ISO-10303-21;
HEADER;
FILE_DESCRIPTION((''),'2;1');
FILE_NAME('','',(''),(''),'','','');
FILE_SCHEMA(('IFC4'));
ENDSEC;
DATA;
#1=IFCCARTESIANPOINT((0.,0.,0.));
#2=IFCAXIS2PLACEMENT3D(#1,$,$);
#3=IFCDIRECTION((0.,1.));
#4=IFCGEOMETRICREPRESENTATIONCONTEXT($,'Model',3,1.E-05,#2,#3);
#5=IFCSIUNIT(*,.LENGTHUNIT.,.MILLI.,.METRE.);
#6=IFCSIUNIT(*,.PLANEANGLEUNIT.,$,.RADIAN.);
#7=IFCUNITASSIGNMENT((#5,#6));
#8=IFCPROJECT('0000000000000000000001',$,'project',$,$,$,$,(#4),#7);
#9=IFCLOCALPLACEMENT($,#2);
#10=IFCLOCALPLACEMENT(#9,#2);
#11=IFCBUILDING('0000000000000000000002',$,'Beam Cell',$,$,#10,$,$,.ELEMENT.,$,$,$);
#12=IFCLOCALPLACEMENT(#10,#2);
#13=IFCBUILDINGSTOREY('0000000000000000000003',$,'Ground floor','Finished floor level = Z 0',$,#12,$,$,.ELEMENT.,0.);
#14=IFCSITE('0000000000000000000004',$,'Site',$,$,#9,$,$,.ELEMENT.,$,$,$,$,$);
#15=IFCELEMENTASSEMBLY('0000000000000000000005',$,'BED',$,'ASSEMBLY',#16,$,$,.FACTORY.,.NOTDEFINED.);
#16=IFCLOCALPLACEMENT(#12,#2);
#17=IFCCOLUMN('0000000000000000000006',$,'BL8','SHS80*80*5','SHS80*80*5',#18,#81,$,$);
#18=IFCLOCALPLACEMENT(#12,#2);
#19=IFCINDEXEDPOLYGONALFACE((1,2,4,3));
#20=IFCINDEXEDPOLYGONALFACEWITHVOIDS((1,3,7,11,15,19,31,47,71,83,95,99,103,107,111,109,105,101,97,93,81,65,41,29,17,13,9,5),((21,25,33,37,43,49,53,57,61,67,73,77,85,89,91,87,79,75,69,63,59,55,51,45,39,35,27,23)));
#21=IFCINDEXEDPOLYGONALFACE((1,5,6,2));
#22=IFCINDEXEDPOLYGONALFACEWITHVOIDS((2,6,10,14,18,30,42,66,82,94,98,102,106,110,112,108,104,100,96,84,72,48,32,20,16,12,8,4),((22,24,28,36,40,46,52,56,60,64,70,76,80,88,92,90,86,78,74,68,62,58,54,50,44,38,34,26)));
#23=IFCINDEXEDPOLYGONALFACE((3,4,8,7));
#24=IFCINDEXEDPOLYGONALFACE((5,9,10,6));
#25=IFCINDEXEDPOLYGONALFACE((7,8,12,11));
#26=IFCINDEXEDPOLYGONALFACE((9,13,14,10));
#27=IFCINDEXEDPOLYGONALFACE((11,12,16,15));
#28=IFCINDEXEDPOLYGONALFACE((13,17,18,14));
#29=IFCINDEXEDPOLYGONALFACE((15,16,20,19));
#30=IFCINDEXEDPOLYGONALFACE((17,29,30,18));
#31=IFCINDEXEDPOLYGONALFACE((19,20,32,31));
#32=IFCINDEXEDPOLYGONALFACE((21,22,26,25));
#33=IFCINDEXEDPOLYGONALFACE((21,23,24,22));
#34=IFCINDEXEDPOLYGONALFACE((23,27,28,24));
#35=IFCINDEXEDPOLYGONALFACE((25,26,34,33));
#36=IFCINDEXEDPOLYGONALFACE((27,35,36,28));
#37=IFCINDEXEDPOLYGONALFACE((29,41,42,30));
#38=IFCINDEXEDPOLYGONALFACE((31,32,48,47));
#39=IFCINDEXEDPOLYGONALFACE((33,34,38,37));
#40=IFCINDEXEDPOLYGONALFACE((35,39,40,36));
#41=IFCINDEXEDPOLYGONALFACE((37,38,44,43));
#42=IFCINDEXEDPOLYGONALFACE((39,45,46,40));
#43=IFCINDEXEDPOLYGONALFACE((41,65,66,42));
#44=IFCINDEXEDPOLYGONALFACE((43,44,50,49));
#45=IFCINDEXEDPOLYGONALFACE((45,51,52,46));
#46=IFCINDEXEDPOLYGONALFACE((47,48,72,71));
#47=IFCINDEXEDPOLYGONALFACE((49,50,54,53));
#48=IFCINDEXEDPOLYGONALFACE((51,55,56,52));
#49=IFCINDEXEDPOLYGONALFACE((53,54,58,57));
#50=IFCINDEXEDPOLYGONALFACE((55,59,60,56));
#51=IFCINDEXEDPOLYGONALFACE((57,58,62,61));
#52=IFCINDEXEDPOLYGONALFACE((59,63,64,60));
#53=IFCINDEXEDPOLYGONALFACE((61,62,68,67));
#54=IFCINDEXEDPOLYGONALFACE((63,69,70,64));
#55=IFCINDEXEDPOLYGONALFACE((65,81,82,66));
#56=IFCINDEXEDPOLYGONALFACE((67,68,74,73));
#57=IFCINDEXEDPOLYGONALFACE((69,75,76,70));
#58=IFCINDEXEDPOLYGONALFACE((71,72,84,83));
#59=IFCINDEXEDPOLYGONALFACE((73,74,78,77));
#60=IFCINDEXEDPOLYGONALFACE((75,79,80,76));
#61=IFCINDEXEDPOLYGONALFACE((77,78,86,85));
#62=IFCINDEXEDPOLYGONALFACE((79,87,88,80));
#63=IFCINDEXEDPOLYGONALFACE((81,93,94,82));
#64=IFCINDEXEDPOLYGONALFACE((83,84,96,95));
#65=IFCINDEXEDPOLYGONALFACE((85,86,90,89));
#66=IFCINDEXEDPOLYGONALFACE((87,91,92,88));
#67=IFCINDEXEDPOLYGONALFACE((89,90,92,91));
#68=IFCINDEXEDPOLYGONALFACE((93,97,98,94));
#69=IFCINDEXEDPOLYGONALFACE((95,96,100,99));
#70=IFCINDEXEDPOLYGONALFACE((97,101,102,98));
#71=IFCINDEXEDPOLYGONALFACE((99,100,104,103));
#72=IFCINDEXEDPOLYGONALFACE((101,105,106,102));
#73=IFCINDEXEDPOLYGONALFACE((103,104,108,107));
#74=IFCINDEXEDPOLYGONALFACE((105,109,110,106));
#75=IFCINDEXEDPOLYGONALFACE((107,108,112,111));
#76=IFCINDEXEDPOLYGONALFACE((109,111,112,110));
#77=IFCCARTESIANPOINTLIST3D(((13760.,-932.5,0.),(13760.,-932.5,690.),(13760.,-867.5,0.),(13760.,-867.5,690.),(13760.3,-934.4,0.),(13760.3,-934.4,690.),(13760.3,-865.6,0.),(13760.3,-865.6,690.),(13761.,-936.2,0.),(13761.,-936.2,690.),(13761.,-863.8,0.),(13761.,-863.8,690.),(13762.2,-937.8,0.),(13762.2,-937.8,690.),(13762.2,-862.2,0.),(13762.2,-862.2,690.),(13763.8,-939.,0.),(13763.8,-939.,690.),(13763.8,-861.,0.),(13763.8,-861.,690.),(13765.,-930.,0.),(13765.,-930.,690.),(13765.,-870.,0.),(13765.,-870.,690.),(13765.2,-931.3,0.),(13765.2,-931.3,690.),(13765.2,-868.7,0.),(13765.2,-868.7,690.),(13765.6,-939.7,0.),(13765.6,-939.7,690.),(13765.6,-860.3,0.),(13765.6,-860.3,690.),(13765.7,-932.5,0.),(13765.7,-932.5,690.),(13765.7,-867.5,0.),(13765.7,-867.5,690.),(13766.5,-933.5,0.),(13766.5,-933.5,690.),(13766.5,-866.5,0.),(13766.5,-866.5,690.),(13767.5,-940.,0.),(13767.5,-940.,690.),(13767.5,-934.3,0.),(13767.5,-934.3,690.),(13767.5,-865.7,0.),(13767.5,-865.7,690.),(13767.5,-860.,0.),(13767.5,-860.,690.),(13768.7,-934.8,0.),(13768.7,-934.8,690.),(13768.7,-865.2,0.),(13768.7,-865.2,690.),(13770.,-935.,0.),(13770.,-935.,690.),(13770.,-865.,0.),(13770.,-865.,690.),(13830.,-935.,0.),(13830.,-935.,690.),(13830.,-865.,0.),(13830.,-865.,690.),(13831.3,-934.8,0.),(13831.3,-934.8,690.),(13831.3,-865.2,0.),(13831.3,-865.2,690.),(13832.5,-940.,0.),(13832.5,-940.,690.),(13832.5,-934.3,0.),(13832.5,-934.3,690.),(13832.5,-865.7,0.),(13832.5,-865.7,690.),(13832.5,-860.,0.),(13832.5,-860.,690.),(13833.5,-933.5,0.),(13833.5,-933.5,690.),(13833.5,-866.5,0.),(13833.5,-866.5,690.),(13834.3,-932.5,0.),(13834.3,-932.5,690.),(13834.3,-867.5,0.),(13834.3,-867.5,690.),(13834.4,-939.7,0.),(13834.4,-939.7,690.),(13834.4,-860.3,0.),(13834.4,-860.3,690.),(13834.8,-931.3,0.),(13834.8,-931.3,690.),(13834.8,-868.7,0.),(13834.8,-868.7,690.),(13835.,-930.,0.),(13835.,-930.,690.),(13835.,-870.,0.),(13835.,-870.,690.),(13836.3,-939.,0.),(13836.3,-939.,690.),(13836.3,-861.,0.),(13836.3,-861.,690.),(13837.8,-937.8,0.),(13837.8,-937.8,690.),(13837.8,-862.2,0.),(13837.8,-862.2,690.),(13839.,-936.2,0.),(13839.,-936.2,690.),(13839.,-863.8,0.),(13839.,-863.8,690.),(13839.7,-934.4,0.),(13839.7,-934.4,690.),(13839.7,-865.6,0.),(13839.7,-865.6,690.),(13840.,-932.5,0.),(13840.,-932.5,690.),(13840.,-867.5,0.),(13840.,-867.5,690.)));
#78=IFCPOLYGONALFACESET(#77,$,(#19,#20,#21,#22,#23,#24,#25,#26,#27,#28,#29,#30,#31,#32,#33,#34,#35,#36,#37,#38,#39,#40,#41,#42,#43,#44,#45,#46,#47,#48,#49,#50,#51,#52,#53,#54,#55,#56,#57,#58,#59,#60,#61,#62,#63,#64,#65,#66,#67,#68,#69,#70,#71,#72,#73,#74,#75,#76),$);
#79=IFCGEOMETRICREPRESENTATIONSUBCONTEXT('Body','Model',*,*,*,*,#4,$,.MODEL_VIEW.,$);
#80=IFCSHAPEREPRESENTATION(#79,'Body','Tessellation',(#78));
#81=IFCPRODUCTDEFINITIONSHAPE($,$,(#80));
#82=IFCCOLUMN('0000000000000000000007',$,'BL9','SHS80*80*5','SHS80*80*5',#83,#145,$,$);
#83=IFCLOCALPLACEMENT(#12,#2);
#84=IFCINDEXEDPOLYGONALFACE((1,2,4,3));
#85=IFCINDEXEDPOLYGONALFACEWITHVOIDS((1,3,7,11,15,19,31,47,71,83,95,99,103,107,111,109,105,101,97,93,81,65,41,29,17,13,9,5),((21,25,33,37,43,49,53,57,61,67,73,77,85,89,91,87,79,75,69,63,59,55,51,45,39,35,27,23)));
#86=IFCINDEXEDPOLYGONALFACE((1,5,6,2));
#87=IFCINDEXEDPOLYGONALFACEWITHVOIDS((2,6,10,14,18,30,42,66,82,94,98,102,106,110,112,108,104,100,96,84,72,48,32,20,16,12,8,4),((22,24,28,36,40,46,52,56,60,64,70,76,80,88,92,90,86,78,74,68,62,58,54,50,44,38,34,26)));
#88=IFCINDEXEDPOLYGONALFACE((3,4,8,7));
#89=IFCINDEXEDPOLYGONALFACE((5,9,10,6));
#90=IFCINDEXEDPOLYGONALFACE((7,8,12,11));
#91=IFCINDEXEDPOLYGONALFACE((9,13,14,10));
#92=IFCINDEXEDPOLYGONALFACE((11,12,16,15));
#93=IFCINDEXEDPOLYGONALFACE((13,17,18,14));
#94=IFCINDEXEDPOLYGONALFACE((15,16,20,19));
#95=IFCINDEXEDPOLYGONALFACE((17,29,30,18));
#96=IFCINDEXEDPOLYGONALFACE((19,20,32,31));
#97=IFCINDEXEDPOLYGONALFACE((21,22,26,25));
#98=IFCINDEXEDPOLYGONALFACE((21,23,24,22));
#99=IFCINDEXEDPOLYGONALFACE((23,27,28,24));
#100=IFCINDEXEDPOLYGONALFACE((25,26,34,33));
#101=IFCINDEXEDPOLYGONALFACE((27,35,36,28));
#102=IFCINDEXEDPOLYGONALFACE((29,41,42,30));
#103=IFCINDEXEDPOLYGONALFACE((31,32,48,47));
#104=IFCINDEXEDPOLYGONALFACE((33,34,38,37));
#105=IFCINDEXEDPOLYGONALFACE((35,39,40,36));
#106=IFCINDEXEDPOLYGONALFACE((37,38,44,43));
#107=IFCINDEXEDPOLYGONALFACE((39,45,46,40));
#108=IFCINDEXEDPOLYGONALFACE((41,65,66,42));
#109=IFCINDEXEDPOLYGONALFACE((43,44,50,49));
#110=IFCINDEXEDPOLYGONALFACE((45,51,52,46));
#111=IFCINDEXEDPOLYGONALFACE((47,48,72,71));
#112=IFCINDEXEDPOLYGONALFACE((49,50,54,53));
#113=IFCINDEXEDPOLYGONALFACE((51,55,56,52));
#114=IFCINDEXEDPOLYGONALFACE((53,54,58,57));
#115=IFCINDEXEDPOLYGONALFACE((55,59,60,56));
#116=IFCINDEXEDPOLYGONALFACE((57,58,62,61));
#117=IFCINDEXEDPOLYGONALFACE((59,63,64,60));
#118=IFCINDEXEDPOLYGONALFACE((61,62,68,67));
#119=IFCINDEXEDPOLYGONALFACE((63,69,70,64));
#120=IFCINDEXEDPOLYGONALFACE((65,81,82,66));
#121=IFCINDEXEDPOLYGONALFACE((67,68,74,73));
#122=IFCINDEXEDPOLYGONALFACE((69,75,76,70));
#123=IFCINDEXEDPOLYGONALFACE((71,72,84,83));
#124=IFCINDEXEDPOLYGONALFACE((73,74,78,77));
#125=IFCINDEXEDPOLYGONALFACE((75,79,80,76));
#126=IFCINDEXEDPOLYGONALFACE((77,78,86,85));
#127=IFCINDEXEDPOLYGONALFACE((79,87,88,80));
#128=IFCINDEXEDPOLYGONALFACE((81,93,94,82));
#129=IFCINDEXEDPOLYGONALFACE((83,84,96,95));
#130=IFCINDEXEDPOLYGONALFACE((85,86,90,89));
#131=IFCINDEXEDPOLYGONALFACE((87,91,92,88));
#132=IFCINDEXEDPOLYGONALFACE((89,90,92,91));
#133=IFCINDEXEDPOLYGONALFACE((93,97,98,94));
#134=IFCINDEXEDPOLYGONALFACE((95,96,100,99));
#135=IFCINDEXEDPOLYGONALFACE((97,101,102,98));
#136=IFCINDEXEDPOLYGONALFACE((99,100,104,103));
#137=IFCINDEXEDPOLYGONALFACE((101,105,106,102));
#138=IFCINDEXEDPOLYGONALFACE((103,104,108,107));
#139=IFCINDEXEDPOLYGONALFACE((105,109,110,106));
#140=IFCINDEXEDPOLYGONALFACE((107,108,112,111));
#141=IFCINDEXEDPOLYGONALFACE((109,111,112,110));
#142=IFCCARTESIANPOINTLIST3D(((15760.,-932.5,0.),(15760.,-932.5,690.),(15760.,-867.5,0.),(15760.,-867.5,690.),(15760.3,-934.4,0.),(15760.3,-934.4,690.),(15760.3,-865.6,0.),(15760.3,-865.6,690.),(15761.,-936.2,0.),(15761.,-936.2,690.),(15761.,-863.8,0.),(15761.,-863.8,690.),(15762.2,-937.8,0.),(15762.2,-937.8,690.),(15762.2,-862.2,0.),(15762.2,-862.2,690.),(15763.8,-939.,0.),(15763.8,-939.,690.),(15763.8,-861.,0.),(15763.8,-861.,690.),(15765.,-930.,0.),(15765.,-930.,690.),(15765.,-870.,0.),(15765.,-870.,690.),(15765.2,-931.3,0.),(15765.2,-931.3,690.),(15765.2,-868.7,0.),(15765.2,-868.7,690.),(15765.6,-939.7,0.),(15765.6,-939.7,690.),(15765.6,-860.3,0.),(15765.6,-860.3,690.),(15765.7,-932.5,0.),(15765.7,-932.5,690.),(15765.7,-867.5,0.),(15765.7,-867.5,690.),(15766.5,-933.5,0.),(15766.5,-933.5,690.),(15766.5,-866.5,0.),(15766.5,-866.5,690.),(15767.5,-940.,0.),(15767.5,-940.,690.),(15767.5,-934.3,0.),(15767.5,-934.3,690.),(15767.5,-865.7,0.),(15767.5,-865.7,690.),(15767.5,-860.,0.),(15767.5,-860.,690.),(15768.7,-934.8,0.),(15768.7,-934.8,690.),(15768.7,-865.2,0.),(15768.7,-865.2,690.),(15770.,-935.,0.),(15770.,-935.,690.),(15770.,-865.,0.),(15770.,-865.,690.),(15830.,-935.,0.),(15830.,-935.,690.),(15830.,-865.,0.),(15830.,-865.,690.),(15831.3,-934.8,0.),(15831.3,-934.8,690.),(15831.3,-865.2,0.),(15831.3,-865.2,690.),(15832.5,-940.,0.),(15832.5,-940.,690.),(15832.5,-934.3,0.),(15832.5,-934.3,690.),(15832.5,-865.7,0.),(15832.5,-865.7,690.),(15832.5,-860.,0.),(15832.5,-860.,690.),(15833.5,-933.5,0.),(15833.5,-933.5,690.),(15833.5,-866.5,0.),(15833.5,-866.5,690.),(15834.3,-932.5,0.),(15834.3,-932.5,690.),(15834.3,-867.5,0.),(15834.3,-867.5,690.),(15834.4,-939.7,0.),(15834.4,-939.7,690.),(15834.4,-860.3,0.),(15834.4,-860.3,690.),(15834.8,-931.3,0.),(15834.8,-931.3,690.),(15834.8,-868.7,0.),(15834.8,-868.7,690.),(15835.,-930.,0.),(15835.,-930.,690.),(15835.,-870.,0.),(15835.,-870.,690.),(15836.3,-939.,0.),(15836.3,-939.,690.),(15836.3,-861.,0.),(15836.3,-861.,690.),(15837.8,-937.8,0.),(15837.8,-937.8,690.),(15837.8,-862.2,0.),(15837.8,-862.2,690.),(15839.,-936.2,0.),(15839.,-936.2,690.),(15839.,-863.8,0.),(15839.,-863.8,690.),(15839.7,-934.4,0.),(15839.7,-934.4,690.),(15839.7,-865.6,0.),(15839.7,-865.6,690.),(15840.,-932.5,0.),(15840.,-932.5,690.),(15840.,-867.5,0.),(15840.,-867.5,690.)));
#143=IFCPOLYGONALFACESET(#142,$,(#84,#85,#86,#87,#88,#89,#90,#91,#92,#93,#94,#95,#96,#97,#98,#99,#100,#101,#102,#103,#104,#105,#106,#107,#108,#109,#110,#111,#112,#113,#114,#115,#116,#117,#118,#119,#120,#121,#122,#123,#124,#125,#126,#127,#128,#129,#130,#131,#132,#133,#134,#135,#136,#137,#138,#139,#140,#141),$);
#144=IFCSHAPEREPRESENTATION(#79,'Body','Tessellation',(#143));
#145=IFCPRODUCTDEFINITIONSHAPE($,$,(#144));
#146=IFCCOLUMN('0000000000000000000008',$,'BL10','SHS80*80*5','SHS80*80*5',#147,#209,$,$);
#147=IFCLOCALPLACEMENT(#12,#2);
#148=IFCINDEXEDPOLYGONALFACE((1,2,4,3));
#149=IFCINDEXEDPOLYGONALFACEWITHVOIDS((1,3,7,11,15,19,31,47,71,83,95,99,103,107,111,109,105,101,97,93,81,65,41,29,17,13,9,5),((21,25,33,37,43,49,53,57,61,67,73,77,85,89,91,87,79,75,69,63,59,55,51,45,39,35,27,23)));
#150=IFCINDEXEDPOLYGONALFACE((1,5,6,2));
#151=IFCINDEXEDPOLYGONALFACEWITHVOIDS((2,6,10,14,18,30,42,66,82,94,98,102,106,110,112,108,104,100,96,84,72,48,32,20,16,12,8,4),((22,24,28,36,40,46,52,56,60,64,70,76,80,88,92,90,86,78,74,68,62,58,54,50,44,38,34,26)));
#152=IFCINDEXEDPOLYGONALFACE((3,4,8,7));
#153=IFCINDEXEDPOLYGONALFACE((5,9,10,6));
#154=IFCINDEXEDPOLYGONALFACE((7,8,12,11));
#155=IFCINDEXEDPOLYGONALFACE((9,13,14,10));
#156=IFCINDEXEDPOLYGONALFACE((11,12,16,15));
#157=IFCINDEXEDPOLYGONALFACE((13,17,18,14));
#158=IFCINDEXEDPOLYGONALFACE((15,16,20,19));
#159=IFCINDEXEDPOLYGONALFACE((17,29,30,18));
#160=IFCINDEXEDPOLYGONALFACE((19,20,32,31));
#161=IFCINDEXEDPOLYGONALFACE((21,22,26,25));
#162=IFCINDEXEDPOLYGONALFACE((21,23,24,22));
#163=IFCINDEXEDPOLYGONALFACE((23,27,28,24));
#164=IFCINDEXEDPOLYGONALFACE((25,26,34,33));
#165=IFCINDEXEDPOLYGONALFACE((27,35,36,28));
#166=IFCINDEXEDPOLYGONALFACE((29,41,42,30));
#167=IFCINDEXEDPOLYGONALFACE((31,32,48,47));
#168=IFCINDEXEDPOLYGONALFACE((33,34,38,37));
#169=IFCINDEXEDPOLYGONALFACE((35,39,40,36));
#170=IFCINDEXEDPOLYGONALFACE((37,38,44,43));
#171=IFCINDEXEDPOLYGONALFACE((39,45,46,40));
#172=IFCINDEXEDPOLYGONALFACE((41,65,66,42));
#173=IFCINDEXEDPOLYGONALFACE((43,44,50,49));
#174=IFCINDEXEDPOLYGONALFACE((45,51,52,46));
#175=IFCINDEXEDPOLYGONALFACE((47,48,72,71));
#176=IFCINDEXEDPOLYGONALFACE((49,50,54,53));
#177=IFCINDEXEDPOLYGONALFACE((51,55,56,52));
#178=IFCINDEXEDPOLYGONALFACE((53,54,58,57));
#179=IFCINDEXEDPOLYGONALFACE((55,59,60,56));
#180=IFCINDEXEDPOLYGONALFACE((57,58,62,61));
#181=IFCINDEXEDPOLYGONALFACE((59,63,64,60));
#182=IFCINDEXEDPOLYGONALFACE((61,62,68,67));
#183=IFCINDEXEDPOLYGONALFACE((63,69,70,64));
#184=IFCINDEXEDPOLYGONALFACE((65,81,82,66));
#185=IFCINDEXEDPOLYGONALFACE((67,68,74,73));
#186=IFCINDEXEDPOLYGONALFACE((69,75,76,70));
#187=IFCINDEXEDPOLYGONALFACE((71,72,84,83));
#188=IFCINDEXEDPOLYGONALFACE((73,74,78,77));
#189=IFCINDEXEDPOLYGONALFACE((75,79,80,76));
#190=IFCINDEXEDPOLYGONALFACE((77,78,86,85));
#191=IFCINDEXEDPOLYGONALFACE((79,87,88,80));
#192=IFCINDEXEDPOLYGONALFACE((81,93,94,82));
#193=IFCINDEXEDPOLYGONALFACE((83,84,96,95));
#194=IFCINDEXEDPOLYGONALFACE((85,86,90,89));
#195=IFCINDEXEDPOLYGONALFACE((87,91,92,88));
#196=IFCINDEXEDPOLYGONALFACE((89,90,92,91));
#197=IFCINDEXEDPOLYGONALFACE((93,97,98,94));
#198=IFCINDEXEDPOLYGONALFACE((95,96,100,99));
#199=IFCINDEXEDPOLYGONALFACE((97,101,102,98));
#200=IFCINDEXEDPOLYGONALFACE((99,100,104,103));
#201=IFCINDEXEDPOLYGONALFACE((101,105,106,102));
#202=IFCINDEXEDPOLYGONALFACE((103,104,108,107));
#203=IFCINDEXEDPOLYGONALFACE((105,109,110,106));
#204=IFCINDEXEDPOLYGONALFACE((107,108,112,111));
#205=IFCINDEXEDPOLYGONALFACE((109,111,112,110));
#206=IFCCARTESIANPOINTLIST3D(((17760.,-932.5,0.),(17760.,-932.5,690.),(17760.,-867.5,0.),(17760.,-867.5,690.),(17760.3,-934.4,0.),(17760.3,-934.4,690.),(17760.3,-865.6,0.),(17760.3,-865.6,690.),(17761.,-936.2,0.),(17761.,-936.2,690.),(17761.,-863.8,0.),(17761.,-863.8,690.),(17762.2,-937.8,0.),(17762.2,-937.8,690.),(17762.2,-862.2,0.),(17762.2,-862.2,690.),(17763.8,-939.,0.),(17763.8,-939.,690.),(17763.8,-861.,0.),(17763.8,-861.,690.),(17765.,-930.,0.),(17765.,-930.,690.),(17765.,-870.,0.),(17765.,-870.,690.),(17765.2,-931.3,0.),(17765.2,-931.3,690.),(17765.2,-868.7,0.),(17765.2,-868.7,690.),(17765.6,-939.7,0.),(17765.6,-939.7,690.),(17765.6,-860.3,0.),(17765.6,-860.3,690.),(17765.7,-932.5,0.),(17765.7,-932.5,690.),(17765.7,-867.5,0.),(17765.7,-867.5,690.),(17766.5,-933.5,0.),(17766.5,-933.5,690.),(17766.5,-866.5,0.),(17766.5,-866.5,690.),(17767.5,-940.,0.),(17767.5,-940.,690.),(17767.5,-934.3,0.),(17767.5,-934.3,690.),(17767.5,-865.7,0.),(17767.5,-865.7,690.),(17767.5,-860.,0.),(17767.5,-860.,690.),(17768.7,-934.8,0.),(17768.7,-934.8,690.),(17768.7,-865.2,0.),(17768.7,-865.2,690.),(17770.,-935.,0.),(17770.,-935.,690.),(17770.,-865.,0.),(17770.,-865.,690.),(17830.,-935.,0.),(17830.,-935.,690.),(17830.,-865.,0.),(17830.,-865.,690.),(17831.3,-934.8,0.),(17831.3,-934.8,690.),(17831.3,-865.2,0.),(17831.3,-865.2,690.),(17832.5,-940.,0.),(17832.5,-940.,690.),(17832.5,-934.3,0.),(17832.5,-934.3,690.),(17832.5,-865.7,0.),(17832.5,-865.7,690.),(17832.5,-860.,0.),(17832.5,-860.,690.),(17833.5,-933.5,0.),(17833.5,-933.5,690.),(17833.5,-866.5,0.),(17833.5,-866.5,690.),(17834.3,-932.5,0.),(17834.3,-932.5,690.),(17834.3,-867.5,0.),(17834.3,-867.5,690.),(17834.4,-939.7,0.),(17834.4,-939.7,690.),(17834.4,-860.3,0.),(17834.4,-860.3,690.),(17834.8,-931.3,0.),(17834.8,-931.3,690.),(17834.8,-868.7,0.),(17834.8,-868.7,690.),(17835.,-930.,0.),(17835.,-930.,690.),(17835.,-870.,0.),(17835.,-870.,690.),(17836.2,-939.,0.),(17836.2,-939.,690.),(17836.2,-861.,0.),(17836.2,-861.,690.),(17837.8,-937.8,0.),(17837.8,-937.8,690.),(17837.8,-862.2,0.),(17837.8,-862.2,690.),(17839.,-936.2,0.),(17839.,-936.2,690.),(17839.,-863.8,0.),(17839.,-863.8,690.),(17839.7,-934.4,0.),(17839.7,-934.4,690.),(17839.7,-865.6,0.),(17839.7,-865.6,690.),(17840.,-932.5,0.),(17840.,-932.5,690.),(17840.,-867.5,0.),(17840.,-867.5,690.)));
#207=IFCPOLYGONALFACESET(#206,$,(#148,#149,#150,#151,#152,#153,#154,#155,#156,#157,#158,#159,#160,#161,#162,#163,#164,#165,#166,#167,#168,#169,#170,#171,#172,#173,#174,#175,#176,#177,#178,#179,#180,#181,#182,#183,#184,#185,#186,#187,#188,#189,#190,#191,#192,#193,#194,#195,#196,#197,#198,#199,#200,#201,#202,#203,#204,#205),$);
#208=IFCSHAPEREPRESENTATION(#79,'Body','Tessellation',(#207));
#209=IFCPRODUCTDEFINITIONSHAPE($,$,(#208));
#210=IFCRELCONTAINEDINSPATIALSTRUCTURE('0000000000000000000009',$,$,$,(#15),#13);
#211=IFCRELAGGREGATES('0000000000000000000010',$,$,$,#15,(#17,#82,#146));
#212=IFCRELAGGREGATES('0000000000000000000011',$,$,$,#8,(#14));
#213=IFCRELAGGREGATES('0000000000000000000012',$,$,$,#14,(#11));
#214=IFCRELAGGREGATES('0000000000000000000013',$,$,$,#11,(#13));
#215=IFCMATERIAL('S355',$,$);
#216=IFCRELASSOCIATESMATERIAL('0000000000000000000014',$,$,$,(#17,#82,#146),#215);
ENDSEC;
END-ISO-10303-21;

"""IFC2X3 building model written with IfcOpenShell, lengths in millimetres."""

from ifc_helpers import new_model, si_unit, direction, frame, origin, origin_2d, place, context, subcontext, project, spatial, hollow_rectangle, extrude, material, element, aggregate, save


model = new_model("IFC2X3")

# Units and contexts
model_context = context("Model", 3, precision=1e-05, world=origin(), true_north=direction((0.0, 1.0)))
body_context = subcontext(model_context, "Body", "Model", "MODEL_VIEW")
ifc_project = project(units=[si_unit("LENGTHUNIT", "METRE", prefix="MILLI"), si_unit("PLANEANGLEUNIT", "RADIAN")], contexts=[model_context])

# Site, building, storey
site_placement = place(None, origin())
site = spatial("IfcSite", under=ifc_project, at=site_placement, Name="Site", CompositionType="ELEMENT")
building_placement = place(site_placement, origin())
building = spatial("IfcBuilding", under=site, at=building_placement, Name="Beam Cell", CompositionType="ELEMENT")
storey_placement = place(building_placement, origin())
storey = spatial("IfcBuildingStorey", under=building, at=storey_placement, Name="Ground floor", Description="Finished floor level = Z 0", CompositionType="ELEMENT", Elevation=0.0)

# Element assembly, columns
ifc_material = material(Name="S355")
assembly_1_placement = place(storey_placement, origin())
assembly_1 = element("IfcElementAssembly", 1, at=assembly_1_placement, inside=storey, Name="BED", ObjectType="ASSEMBLY", AssemblyPlace="FACTORY", PredefinedType="NOTDEFINED")
column_1_placement = place(storey_placement, frame((13800.0, -900.0, 0.0), z_axis=(0.0, 0.0, 1.0), x_axis=(1.0, 0.0, 0.0)))
column_1 = element("IfcColumn", 2, at=column_1_placement, material=ifc_material, Name="BL8", Description="SHS80*80*5", ObjectType="SHS80*80*5", context=body_context, shape_type="SweptSolid", body=[
    extrude(hollow_rectangle(XDim=80.0, YDim=80.0, WallThickness=5.0, InnerFilletRadius=5.0, OuterFilletRadius=7.5, at=origin_2d()), origin(), (0.0, 0.0, 1.0), 690.0),
])
column_2_placement = place(storey_placement, frame((15800.0, -900.0, 0.0), z_axis=(0.0, 0.0, 1.0), x_axis=(1.0, 0.0, 0.0)))
column_2 = element("IfcColumn", 3, at=column_2_placement, material=ifc_material, Name="BL9", Description="SHS80*80*5", ObjectType="SHS80*80*5", context=body_context, shape_type="SweptSolid", body=[
    extrude(hollow_rectangle(XDim=80.0, YDim=80.0, WallThickness=5.0, InnerFilletRadius=5.0, OuterFilletRadius=7.5, at=origin_2d()), origin(), (0.0, 0.0, 1.0), 690.0),
])
column_3_placement = place(storey_placement, frame((17800.0, -900.0, 0.0), z_axis=(0.0, 0.0, 1.0), x_axis=(1.0, 0.0, 0.0)))
column_3 = element("IfcColumn", 4, at=column_3_placement, material=ifc_material, Name="BL10", Description="SHS80*80*5", ObjectType="SHS80*80*5", context=body_context, shape_type="SweptSolid", body=[
    extrude(hollow_rectangle(XDim=80.0, YDim=80.0, WallThickness=5.0, InnerFilletRadius=5.0, OuterFilletRadius=7.5, at=origin_2d()), origin(), (0.0, 0.0, 1.0), 690.0),
])
aggregate(assembly_1, [column_1, column_2, column_3])

save(model, "model.ifc")
